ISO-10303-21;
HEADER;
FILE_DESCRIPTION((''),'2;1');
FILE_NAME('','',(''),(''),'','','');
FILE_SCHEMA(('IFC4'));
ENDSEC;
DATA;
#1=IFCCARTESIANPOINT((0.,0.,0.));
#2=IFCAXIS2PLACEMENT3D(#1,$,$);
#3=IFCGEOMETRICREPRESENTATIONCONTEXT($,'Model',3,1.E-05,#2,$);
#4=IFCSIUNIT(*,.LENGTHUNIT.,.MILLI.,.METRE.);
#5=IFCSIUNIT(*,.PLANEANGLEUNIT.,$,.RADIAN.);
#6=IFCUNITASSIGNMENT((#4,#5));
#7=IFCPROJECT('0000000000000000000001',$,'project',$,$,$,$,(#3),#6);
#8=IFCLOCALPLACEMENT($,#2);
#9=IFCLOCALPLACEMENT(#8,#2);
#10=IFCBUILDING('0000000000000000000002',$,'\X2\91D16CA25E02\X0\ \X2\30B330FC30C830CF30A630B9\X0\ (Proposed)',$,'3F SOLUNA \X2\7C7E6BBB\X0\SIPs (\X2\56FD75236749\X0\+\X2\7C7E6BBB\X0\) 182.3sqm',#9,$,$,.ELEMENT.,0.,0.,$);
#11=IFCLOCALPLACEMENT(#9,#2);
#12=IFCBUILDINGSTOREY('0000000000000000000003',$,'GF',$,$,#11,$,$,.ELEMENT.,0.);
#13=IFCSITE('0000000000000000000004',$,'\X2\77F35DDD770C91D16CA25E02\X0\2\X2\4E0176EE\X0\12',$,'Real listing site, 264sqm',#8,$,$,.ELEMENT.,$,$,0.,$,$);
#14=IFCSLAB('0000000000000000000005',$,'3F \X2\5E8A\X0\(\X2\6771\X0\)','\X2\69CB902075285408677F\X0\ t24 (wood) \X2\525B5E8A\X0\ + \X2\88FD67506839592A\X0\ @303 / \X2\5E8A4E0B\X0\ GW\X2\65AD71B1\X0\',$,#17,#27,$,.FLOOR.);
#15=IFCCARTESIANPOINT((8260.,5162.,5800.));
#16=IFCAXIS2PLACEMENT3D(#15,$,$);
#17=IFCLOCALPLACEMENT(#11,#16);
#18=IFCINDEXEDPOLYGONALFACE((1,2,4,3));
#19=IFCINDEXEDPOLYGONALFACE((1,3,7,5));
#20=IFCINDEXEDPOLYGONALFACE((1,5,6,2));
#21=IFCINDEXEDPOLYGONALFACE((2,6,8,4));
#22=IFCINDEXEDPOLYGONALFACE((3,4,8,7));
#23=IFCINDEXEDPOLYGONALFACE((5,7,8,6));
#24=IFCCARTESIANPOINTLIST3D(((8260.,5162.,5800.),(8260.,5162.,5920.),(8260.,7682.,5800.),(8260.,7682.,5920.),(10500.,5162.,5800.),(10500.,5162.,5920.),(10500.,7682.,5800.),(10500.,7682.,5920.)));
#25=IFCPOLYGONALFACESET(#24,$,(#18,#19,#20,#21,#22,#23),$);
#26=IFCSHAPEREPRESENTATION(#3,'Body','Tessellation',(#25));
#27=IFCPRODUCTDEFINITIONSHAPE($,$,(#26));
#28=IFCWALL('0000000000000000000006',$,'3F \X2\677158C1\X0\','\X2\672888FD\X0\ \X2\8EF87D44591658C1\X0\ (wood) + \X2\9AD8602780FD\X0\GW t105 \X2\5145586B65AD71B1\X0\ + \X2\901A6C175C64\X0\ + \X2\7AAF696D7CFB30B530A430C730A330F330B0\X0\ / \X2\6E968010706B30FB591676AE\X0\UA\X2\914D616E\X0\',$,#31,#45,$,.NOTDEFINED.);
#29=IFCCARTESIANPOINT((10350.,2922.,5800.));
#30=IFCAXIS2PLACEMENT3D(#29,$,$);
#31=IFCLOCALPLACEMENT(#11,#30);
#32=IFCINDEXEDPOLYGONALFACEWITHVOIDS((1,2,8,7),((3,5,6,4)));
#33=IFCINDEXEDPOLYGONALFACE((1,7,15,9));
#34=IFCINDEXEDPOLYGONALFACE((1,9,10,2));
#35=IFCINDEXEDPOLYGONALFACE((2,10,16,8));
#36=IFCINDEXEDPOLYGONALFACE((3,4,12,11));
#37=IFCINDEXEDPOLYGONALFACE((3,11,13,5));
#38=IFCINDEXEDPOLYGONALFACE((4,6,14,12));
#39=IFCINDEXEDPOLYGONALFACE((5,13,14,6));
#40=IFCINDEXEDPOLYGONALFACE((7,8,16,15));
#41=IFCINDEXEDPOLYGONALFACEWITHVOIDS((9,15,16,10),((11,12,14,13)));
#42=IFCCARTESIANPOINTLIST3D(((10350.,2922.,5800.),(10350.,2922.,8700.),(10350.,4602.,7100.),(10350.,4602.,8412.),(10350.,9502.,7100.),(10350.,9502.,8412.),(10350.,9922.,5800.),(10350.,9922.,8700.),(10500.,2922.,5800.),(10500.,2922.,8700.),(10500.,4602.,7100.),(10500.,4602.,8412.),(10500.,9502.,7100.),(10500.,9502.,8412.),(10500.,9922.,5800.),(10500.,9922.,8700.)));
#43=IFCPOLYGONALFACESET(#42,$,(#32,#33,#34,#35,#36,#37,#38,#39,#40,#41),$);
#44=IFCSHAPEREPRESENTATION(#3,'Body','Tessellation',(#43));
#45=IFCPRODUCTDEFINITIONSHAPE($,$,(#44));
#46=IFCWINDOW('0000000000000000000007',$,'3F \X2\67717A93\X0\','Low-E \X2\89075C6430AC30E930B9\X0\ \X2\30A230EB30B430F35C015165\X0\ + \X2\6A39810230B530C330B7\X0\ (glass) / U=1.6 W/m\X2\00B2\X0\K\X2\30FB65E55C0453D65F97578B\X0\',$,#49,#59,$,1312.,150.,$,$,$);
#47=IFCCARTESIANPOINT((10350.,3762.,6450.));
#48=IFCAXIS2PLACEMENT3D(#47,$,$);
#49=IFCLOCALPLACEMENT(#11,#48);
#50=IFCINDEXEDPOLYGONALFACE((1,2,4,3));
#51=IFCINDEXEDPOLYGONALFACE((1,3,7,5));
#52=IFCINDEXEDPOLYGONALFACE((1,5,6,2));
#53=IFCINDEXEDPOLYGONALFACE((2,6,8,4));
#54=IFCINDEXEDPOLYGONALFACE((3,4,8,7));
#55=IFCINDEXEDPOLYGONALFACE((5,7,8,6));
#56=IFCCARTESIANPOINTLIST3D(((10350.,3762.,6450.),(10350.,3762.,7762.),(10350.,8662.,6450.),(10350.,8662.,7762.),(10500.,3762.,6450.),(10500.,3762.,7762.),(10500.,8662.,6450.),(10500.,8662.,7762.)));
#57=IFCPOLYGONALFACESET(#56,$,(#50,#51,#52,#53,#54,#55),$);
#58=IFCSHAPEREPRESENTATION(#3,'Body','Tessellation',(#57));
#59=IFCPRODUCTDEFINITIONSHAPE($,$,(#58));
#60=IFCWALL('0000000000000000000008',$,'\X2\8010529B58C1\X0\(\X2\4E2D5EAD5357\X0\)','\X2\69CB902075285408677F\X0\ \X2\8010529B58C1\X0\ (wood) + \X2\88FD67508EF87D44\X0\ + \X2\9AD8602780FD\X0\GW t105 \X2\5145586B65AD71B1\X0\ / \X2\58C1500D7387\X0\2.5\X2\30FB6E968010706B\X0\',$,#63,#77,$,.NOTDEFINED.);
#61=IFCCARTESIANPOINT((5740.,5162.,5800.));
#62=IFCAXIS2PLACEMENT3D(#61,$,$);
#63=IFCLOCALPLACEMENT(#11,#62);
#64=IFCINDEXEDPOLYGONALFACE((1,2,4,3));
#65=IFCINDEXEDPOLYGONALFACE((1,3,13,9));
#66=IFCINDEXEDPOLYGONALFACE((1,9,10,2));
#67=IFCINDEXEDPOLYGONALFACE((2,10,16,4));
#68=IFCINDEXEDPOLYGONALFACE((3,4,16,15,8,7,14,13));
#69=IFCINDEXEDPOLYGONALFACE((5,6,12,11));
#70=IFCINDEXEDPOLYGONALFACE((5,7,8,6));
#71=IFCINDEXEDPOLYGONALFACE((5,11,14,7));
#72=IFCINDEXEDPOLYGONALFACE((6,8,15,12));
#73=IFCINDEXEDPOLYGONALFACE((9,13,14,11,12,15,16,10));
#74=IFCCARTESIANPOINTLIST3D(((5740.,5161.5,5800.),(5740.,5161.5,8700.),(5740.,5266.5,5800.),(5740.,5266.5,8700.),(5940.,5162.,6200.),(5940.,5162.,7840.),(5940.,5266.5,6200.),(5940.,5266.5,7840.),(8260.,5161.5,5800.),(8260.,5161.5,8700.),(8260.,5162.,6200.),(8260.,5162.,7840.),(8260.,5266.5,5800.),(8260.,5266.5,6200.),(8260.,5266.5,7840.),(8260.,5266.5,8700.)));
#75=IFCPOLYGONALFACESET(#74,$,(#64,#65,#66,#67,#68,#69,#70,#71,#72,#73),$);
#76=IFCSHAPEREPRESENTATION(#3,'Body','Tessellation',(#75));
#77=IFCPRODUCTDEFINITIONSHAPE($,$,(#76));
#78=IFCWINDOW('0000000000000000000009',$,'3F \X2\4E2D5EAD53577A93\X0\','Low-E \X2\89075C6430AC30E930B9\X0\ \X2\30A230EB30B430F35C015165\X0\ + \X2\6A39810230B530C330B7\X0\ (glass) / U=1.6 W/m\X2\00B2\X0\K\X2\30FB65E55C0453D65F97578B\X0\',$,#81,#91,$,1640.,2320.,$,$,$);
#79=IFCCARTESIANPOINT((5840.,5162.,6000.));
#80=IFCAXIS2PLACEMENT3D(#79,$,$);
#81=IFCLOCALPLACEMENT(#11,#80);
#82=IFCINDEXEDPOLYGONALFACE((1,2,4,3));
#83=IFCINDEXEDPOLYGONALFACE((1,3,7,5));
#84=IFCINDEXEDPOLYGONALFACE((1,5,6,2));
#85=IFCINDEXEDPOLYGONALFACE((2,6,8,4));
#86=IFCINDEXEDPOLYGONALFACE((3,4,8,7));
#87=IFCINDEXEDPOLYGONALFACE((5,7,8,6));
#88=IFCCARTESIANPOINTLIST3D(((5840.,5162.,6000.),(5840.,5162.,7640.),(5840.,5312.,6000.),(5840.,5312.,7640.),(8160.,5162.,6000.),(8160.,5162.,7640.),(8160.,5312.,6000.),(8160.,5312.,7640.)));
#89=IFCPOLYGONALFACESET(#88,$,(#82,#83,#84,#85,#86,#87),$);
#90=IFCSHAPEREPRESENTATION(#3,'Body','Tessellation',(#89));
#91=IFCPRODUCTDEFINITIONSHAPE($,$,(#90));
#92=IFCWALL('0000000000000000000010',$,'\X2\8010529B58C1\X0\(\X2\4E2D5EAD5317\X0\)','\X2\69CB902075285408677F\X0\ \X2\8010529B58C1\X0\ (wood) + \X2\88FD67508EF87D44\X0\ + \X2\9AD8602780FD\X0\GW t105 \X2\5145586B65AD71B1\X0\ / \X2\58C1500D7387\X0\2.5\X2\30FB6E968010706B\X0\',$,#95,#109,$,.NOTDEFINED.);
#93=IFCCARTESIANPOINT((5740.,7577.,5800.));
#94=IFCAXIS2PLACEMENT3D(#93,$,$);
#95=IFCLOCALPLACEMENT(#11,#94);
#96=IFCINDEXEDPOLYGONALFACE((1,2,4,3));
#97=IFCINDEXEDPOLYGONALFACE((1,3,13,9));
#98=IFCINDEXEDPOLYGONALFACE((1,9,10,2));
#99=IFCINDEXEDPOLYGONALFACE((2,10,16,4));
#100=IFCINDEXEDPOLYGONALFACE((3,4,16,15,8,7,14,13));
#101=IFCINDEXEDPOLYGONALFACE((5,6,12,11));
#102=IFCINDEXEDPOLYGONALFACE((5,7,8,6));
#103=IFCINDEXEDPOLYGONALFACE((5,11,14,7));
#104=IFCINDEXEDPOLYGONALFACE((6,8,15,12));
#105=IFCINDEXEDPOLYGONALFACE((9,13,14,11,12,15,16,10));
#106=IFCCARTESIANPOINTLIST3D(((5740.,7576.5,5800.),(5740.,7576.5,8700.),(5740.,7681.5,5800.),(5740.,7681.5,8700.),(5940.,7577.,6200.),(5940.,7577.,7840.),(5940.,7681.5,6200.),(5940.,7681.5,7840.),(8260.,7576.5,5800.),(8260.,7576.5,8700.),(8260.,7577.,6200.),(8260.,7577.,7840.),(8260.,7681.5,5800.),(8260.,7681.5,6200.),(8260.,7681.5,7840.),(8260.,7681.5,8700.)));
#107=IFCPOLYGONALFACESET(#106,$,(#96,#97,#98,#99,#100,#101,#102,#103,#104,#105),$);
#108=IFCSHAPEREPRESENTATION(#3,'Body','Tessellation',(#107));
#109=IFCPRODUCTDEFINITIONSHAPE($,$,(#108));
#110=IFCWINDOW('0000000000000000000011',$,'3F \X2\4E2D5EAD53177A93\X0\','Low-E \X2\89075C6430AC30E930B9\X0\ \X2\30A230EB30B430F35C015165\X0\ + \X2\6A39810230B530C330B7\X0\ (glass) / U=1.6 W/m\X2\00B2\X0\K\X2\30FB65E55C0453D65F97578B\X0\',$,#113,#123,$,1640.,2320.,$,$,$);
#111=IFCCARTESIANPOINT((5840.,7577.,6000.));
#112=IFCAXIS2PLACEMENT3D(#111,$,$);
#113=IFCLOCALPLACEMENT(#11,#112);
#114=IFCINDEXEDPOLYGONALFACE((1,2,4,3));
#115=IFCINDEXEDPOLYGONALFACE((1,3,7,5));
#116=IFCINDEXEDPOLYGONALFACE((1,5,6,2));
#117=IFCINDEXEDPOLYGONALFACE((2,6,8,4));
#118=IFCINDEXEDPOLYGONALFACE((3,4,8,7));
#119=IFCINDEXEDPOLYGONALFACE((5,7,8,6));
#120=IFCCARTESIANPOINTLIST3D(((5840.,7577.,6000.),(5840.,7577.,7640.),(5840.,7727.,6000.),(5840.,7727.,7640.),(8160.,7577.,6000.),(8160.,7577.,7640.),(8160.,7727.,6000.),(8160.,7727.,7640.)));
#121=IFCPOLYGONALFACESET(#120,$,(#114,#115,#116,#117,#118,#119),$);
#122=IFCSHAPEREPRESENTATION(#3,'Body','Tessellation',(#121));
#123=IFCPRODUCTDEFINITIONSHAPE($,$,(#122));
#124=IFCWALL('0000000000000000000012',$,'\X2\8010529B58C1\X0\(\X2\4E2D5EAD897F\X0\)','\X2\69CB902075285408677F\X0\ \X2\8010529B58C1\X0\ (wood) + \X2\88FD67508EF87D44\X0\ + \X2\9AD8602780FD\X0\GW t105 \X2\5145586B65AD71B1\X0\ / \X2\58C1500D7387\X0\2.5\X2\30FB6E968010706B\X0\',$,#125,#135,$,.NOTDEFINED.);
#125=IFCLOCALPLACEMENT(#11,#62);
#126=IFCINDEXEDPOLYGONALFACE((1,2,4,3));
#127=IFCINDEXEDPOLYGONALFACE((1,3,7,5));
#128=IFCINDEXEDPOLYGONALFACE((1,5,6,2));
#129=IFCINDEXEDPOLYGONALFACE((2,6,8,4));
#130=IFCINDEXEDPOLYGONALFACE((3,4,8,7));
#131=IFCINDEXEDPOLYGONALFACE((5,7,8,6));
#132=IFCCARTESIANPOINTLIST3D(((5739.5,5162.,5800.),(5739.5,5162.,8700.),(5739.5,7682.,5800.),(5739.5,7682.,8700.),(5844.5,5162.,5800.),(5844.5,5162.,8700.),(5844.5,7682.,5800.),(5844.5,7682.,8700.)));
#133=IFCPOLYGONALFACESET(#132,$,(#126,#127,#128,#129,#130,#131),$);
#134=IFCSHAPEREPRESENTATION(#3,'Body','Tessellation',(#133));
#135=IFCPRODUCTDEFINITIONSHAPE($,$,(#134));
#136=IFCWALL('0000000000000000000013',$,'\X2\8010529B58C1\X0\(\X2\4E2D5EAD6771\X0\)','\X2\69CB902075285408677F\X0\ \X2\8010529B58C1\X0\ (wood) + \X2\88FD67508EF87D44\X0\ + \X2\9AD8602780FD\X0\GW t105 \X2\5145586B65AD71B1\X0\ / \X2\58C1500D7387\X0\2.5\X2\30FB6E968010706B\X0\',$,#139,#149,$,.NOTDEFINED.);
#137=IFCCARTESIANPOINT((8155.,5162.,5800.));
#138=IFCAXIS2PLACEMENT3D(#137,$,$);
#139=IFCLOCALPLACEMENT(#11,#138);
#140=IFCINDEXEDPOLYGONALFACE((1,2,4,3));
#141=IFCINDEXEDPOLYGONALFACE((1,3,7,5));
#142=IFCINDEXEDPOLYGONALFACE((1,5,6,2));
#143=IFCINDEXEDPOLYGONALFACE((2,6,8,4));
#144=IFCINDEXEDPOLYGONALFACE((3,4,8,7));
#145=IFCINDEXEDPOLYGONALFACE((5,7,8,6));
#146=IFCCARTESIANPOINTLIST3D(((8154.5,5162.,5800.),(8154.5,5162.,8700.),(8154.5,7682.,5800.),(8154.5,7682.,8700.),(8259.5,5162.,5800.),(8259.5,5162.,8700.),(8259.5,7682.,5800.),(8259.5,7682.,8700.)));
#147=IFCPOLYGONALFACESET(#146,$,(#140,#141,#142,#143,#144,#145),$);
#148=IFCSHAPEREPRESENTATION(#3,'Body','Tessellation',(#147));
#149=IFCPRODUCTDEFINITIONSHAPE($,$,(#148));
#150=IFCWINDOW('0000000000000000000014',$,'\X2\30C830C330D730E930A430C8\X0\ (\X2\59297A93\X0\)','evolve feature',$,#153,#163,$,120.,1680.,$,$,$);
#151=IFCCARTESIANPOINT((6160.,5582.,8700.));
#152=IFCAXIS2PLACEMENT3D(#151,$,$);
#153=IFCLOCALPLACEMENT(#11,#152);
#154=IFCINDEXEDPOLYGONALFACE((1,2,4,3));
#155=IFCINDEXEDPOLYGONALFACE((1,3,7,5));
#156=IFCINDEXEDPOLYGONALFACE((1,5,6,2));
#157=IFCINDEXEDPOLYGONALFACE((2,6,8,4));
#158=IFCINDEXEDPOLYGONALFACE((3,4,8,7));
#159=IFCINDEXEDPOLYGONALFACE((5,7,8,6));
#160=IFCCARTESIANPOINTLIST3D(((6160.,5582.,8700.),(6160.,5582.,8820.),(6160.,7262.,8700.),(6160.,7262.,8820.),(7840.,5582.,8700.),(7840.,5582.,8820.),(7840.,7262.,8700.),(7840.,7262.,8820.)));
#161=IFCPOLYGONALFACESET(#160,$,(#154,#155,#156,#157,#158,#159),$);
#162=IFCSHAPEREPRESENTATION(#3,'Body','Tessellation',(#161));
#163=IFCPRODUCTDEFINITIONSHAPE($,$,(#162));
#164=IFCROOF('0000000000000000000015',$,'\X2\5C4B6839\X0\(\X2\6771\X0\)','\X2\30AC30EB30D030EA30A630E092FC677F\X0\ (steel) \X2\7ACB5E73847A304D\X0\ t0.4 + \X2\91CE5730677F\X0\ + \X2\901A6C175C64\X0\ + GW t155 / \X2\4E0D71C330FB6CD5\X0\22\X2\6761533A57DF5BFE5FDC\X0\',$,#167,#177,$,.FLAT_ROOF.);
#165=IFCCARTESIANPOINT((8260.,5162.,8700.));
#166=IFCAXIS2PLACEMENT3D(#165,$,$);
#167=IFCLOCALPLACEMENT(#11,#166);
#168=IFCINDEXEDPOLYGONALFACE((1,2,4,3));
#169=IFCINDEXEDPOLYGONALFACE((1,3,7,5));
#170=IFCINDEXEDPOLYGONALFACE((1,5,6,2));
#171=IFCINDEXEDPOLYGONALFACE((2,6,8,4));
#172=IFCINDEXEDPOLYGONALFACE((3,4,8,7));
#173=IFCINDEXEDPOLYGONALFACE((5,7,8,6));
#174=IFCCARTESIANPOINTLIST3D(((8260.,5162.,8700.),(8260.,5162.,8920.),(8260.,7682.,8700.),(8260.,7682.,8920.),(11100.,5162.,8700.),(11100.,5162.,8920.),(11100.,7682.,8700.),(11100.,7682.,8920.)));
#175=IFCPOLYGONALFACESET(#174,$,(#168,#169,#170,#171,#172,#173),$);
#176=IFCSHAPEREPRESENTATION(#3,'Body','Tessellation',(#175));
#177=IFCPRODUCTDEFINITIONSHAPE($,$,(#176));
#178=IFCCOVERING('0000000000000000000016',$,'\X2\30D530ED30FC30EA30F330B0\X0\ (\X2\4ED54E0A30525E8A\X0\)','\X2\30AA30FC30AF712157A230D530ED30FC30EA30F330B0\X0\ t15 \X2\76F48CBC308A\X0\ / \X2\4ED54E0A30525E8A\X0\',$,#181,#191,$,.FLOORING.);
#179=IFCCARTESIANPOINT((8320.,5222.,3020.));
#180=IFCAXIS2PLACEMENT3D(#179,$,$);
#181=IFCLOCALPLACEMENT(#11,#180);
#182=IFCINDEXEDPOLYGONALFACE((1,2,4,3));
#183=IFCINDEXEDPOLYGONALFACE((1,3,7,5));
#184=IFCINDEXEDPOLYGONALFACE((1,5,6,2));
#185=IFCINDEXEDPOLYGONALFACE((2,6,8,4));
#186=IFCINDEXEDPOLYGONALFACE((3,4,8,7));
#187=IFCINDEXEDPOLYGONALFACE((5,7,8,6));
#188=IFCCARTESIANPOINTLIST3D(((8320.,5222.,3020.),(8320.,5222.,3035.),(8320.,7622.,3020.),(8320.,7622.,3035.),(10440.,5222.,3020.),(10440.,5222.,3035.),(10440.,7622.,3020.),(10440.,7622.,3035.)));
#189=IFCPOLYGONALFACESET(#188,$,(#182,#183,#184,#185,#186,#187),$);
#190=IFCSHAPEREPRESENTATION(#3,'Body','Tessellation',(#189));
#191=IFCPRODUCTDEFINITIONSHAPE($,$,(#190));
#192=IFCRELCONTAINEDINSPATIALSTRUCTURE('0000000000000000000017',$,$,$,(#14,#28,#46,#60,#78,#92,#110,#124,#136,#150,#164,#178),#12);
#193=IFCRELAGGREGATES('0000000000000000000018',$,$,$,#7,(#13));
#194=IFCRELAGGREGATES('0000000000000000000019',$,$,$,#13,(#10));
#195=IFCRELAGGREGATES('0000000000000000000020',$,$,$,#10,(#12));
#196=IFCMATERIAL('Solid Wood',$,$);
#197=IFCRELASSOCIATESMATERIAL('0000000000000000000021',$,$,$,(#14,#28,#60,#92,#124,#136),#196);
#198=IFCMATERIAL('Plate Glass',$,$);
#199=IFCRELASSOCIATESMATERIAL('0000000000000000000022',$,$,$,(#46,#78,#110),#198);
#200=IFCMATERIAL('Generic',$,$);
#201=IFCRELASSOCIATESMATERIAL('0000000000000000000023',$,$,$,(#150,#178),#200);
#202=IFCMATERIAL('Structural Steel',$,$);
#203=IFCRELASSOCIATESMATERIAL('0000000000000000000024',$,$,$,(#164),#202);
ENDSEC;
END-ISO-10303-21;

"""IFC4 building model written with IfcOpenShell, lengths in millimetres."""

from ifc_helpers import new_model, si_unit, frame, frame_2d, origin, place, context, project, spatial, rectangle, extrude, material, element, fill, save


model = new_model("IFC4")

# Units and contexts
model_context = context("Model", 3, precision=1e-05, world=origin())
ifc_project = project(units=[si_unit("LENGTHUNIT", "METRE", prefix="MILLI"), si_unit("PLANEANGLEUNIT", "RADIAN")], contexts=[model_context])

# Site, building, storey
site_placement = place(None, origin())
site = spatial("IfcSite", under=ifc_project, at=site_placement, Name="石川県金沢市2丁目12", ObjectType="Real listing site, 264sqm", CompositionType="ELEMENT", RefElevation=0.0)
building_placement = place(site_placement, origin())
building = spatial("IfcBuilding", under=site, at=building_placement, Name="金沢市 コートハウス (Proposed)", ObjectType="3F SOLUNA 籾殻SIPs (国産杉+籾殻) 182.3sqm", CompositionType="ELEMENT", ElevationOfRefHeight=0.0, ElevationOfTerrain=0.0)
storey_placement = place(building_placement, origin())
storey = spatial("IfcBuildingStorey", under=building, at=storey_placement, Name="GF", CompositionType="ELEMENT", Elevation=0.0)

# Slab
ifc_material_1 = material(Name="Solid Wood")
slab_placement = place(storey_placement, frame((8260.0, 5162.0, 5800.0)))
element("IfcSlab", 1, at=slab_placement, inside=storey, material=ifc_material_1, Name="3F 床(東)", Description="構造用合板 t24 (wood) 剛床 + 製材根太 @303 / 床下 GW断熱", PredefinedType="FLOOR", context=model_context, shape_type="SweptSolid", body=[
    extrude(rectangle(XDim=2240.0, YDim=2520.0, at=frame_2d((1120.0, 1260.0))), frame((8260.0, 5162.0, 5800.0)), (0.0, 0.0, 1.0), 120.0),
])

# Walls, openings, windows
wall_1_placement = place(storey_placement, frame((10350.0, 2922.0, 5800.0)))
wall_1 = element("IfcWall", 2, at=wall_1_placement, inside=storey, material=ifc_material_1, Name="3F 東壁", Description="木製 軸組外壁 (wood) + 高性能GW t105 充填断熱 + 通気層 + 窯業系サイディング / 準耐火・外皮UA配慮", PredefinedType="NOTDEFINED", context=model_context, shape_type="SweptSolid", body=[
    extrude(rectangle(XDim=150.0, YDim=7000.0, at=frame_2d((75.0, 3500.0))), frame((10350.0, 2922.0, 5800.0)), (0.0, 0.0, 1.0), 2900.0),
])
opening_1_placement = place(storey_placement, frame((10350.0, 3762.0, 6450.0)))
opening_1 = element("IfcOpeningElement", 3, at=opening_1_placement, cuts=wall_1, PredefinedType="NOTDEFINED", context=model_context, shape_type="SweptSolid", body=[
    extrude(rectangle(XDim=150.0, YDim=4900.0, at=frame_2d((75.0, 2450.0))), frame((10350.0, 3762.0, 6450.0)), (0.0, 0.0, 1.0), 1312.0),
])
ifc_material_2 = material(Name="Plate Glass")
window_1_placement = place(storey_placement, frame((10350.0, 3762.0, 6450.0)))
window_1 = element("IfcWindow", 4, at=window_1_placement, inside=storey, material=ifc_material_2, Name="3F 東窓", Description="Low-E 複層ガラス アルゴン封入 + 樹脂サッシ (glass) / U=1.6 W/m²K・日射取得型", OverallHeight=1312.0, OverallWidth=150.0, context=model_context, shape_type="SweptSolid", body=[
    extrude(rectangle(XDim=150.0, YDim=4900.0, at=frame_2d((75.0, 2450.0))), frame((10350.0, 3762.0, 6450.0)), (0.0, 0.0, 1.0), 1312.0),
])
fill(opening_1, window_1)
wall_2_placement = place(storey_placement, frame((5740.0, 5162.0, 5800.0)))
wall_2 = element("IfcWall", 5, at=wall_2_placement, inside=storey, material=ifc_material_1, Name="耐力壁(中庭南)", Description="構造用合板 耐力壁 (wood) + 製材軸組 + 高性能GW t105 充填断熱 / 壁倍率2.5・準耐火", PredefinedType="NOTDEFINED", context=model_context, shape_type="SweptSolid", body=[
    extrude(rectangle(XDim=2520.0, YDim=105.0, at=frame_2d((1260.0, 52.0))), frame((5740.0, 5162.0, 5800.0)), (0.0, 0.0, 1.0), 2900.0),
])
opening_2_placement = place(storey_placement, frame((5840.0, 5162.0, 6000.0)))
opening_2 = element("IfcOpeningElement", 6, at=opening_2_placement, cuts=wall_2, PredefinedType="NOTDEFINED", context=model_context, shape_type="SweptSolid", body=[
    extrude(rectangle(XDim=2320.0, YDim=150.0, at=frame_2d((1160.0, 75.0))), frame((5840.0, 5162.0, 6000.0)), (0.0, 0.0, 1.0), 1640.0),
])
window_2_placement = place(storey_placement, frame((5840.0, 5162.0, 6000.0)))
window_2 = element("IfcWindow", 7, at=window_2_placement, inside=storey, material=ifc_material_2, Name="3F 中庭南窓", Description="Low-E 複層ガラス アルゴン封入 + 樹脂サッシ (glass) / U=1.6 W/m²K・日射取得型", OverallHeight=1640.0, OverallWidth=2320.0, context=model_context, shape_type="SweptSolid", body=[
    extrude(rectangle(XDim=2320.0, YDim=150.0, at=frame_2d((1160.0, 75.0))), frame((5840.0, 5162.0, 6000.0)), (0.0, 0.0, 1.0), 1640.0),
])
fill(opening_2, window_2)
wall_3_placement = place(storey_placement, frame((5740.0, 7577.0, 5800.0)))
wall_3 = element("IfcWall", 8, at=wall_3_placement, inside=storey, material=ifc_material_1, Name="耐力壁(中庭北)", Description="構造用合板 耐力壁 (wood) + 製材軸組 + 高性能GW t105 充填断熱 / 壁倍率2.5・準耐火", PredefinedType="NOTDEFINED", context=model_context, shape_type="SweptSolid", body=[
    extrude(rectangle(XDim=2520.0, YDim=105.0, at=frame_2d((1260.0, 52.0))), frame((5740.0, 7577.0, 5800.0)), (0.0, 0.0, 1.0), 2900.0),
])
opening_3_placement = place(storey_placement, frame((5840.0, 7577.0, 6000.0)))
opening_3 = element("IfcOpeningElement", 9, at=opening_3_placement, cuts=wall_3, PredefinedType="NOTDEFINED", context=model_context, shape_type="SweptSolid", body=[
    extrude(rectangle(XDim=2320.0, YDim=150.0, at=frame_2d((1160.0, 75.0))), frame((5840.0, 7577.0, 6000.0)), (0.0, 0.0, 1.0), 1640.0),
])
window_3_placement = place(storey_placement, frame((5840.0, 7577.0, 6000.0)))
window_3 = element("IfcWindow", 10, at=window_3_placement, inside=storey, material=ifc_material_2, Name="3F 中庭北窓", Description="Low-E 複層ガラス アルゴン封入 + 樹脂サッシ (glass) / U=1.6 W/m²K・日射取得型", OverallHeight=1640.0, OverallWidth=2320.0, context=model_context, shape_type="SweptSolid", body=[
    extrude(rectangle(XDim=2320.0, YDim=150.0, at=frame_2d((1160.0, 75.0))), frame((5840.0, 7577.0, 6000.0)), (0.0, 0.0, 1.0), 1640.0),
])
fill(opening_3, window_3)

# Walls
wall_4_placement = place(storey_placement, frame((5740.0, 5162.0, 5800.0)))
element("IfcWall", 11, at=wall_4_placement, inside=storey, material=ifc_material_1, Name="耐力壁(中庭西)", Description="構造用合板 耐力壁 (wood) + 製材軸組 + 高性能GW t105 充填断熱 / 壁倍率2.5・準耐火", PredefinedType="NOTDEFINED", context=model_context, shape_type="SweptSolid", body=[
    extrude(rectangle(XDim=105.0, YDim=2520.0, at=frame_2d((52.0, 1260.0))), frame((5740.0, 5162.0, 5800.0)), (0.0, 0.0, 1.0), 2900.0),
])
wall_5_placement = place(storey_placement, frame((8155.0, 5162.0, 5800.0)))
element("IfcWall", 12, at=wall_5_placement, inside=storey, material=ifc_material_1, Name="耐力壁(中庭東)", Description="構造用合板 耐力壁 (wood) + 製材軸組 + 高性能GW t105 充填断熱 / 壁倍率2.5・準耐火", PredefinedType="NOTDEFINED", context=model_context, shape_type="SweptSolid", body=[
    extrude(rectangle(XDim=105.0, YDim=2520.0, at=frame_2d((52.0, 1260.0))), frame((8155.0, 5162.0, 5800.0)), (0.0, 0.0, 1.0), 2900.0),
])

# Window
ifc_material_3 = material(Name="Generic")
window_4_placement = place(storey_placement, frame((6160.0, 5582.0, 8700.0)))
element("IfcWindow", 13, at=window_4_placement, inside=storey, material=ifc_material_3, Name="トップライト (天窓)", Description="evolve feature", OverallHeight=120.0, OverallWidth=1680.0, context=model_context, shape_type="SweptSolid", body=[
    extrude(rectangle(XDim=1680.0, YDim=1680.0, at=frame_2d((840.0, 840.0))), frame((6160.0, 5582.0, 8700.0)), (0.0, 0.0, 1.0), 120.0),
])

# Roof
ifc_material_4 = material(Name="Structural Steel")
for number, where, name in (
    (14, (8260.0, 5162.0, 8700.0), "屋根(東)"),
):
    element("IfcRoof", number, at=place(storey_placement, frame(where)), inside=storey, material=ifc_material_4, Name=name, Description="ガルバリウム鋼板 (steel) 立平葺き t0.4 + 野地板 + 通気層 + GW t155 / 不燃・法22条区域対応", PredefinedType="FLAT_ROOF", context=model_context, shape_type="SweptSolid", body=[
        extrude(rectangle(XDim=2840.0, YDim=2520.0, at=frame_2d((1420.0, 1260.0))), frame((8260.0, 5162.0, 8700.0)), (0.0, 0.0, 1.0), 220.0),
    ])

# Covering
covering_1_placement = place(storey_placement, frame((8320.0, 5222.0, 3020.0)))
element("IfcCovering", 15, at=covering_1_placement, inside=storey, material=ifc_material_3, Name="フローリング (仕上げ床)", Description="オーク無垢フローリング t15 直貼り / 仕上げ床", PredefinedType="FLOORING", context=model_context, shape_type="SweptSolid", body=[
    extrude(rectangle(XDim=2120.0, YDim=2400.0, at=frame_2d((1060.0, 1200.0))), frame((8320.0, 5222.0, 3020.0)), (0.0, 0.0, 1.0), 15.0),
])

save(model, "model.ifc")
